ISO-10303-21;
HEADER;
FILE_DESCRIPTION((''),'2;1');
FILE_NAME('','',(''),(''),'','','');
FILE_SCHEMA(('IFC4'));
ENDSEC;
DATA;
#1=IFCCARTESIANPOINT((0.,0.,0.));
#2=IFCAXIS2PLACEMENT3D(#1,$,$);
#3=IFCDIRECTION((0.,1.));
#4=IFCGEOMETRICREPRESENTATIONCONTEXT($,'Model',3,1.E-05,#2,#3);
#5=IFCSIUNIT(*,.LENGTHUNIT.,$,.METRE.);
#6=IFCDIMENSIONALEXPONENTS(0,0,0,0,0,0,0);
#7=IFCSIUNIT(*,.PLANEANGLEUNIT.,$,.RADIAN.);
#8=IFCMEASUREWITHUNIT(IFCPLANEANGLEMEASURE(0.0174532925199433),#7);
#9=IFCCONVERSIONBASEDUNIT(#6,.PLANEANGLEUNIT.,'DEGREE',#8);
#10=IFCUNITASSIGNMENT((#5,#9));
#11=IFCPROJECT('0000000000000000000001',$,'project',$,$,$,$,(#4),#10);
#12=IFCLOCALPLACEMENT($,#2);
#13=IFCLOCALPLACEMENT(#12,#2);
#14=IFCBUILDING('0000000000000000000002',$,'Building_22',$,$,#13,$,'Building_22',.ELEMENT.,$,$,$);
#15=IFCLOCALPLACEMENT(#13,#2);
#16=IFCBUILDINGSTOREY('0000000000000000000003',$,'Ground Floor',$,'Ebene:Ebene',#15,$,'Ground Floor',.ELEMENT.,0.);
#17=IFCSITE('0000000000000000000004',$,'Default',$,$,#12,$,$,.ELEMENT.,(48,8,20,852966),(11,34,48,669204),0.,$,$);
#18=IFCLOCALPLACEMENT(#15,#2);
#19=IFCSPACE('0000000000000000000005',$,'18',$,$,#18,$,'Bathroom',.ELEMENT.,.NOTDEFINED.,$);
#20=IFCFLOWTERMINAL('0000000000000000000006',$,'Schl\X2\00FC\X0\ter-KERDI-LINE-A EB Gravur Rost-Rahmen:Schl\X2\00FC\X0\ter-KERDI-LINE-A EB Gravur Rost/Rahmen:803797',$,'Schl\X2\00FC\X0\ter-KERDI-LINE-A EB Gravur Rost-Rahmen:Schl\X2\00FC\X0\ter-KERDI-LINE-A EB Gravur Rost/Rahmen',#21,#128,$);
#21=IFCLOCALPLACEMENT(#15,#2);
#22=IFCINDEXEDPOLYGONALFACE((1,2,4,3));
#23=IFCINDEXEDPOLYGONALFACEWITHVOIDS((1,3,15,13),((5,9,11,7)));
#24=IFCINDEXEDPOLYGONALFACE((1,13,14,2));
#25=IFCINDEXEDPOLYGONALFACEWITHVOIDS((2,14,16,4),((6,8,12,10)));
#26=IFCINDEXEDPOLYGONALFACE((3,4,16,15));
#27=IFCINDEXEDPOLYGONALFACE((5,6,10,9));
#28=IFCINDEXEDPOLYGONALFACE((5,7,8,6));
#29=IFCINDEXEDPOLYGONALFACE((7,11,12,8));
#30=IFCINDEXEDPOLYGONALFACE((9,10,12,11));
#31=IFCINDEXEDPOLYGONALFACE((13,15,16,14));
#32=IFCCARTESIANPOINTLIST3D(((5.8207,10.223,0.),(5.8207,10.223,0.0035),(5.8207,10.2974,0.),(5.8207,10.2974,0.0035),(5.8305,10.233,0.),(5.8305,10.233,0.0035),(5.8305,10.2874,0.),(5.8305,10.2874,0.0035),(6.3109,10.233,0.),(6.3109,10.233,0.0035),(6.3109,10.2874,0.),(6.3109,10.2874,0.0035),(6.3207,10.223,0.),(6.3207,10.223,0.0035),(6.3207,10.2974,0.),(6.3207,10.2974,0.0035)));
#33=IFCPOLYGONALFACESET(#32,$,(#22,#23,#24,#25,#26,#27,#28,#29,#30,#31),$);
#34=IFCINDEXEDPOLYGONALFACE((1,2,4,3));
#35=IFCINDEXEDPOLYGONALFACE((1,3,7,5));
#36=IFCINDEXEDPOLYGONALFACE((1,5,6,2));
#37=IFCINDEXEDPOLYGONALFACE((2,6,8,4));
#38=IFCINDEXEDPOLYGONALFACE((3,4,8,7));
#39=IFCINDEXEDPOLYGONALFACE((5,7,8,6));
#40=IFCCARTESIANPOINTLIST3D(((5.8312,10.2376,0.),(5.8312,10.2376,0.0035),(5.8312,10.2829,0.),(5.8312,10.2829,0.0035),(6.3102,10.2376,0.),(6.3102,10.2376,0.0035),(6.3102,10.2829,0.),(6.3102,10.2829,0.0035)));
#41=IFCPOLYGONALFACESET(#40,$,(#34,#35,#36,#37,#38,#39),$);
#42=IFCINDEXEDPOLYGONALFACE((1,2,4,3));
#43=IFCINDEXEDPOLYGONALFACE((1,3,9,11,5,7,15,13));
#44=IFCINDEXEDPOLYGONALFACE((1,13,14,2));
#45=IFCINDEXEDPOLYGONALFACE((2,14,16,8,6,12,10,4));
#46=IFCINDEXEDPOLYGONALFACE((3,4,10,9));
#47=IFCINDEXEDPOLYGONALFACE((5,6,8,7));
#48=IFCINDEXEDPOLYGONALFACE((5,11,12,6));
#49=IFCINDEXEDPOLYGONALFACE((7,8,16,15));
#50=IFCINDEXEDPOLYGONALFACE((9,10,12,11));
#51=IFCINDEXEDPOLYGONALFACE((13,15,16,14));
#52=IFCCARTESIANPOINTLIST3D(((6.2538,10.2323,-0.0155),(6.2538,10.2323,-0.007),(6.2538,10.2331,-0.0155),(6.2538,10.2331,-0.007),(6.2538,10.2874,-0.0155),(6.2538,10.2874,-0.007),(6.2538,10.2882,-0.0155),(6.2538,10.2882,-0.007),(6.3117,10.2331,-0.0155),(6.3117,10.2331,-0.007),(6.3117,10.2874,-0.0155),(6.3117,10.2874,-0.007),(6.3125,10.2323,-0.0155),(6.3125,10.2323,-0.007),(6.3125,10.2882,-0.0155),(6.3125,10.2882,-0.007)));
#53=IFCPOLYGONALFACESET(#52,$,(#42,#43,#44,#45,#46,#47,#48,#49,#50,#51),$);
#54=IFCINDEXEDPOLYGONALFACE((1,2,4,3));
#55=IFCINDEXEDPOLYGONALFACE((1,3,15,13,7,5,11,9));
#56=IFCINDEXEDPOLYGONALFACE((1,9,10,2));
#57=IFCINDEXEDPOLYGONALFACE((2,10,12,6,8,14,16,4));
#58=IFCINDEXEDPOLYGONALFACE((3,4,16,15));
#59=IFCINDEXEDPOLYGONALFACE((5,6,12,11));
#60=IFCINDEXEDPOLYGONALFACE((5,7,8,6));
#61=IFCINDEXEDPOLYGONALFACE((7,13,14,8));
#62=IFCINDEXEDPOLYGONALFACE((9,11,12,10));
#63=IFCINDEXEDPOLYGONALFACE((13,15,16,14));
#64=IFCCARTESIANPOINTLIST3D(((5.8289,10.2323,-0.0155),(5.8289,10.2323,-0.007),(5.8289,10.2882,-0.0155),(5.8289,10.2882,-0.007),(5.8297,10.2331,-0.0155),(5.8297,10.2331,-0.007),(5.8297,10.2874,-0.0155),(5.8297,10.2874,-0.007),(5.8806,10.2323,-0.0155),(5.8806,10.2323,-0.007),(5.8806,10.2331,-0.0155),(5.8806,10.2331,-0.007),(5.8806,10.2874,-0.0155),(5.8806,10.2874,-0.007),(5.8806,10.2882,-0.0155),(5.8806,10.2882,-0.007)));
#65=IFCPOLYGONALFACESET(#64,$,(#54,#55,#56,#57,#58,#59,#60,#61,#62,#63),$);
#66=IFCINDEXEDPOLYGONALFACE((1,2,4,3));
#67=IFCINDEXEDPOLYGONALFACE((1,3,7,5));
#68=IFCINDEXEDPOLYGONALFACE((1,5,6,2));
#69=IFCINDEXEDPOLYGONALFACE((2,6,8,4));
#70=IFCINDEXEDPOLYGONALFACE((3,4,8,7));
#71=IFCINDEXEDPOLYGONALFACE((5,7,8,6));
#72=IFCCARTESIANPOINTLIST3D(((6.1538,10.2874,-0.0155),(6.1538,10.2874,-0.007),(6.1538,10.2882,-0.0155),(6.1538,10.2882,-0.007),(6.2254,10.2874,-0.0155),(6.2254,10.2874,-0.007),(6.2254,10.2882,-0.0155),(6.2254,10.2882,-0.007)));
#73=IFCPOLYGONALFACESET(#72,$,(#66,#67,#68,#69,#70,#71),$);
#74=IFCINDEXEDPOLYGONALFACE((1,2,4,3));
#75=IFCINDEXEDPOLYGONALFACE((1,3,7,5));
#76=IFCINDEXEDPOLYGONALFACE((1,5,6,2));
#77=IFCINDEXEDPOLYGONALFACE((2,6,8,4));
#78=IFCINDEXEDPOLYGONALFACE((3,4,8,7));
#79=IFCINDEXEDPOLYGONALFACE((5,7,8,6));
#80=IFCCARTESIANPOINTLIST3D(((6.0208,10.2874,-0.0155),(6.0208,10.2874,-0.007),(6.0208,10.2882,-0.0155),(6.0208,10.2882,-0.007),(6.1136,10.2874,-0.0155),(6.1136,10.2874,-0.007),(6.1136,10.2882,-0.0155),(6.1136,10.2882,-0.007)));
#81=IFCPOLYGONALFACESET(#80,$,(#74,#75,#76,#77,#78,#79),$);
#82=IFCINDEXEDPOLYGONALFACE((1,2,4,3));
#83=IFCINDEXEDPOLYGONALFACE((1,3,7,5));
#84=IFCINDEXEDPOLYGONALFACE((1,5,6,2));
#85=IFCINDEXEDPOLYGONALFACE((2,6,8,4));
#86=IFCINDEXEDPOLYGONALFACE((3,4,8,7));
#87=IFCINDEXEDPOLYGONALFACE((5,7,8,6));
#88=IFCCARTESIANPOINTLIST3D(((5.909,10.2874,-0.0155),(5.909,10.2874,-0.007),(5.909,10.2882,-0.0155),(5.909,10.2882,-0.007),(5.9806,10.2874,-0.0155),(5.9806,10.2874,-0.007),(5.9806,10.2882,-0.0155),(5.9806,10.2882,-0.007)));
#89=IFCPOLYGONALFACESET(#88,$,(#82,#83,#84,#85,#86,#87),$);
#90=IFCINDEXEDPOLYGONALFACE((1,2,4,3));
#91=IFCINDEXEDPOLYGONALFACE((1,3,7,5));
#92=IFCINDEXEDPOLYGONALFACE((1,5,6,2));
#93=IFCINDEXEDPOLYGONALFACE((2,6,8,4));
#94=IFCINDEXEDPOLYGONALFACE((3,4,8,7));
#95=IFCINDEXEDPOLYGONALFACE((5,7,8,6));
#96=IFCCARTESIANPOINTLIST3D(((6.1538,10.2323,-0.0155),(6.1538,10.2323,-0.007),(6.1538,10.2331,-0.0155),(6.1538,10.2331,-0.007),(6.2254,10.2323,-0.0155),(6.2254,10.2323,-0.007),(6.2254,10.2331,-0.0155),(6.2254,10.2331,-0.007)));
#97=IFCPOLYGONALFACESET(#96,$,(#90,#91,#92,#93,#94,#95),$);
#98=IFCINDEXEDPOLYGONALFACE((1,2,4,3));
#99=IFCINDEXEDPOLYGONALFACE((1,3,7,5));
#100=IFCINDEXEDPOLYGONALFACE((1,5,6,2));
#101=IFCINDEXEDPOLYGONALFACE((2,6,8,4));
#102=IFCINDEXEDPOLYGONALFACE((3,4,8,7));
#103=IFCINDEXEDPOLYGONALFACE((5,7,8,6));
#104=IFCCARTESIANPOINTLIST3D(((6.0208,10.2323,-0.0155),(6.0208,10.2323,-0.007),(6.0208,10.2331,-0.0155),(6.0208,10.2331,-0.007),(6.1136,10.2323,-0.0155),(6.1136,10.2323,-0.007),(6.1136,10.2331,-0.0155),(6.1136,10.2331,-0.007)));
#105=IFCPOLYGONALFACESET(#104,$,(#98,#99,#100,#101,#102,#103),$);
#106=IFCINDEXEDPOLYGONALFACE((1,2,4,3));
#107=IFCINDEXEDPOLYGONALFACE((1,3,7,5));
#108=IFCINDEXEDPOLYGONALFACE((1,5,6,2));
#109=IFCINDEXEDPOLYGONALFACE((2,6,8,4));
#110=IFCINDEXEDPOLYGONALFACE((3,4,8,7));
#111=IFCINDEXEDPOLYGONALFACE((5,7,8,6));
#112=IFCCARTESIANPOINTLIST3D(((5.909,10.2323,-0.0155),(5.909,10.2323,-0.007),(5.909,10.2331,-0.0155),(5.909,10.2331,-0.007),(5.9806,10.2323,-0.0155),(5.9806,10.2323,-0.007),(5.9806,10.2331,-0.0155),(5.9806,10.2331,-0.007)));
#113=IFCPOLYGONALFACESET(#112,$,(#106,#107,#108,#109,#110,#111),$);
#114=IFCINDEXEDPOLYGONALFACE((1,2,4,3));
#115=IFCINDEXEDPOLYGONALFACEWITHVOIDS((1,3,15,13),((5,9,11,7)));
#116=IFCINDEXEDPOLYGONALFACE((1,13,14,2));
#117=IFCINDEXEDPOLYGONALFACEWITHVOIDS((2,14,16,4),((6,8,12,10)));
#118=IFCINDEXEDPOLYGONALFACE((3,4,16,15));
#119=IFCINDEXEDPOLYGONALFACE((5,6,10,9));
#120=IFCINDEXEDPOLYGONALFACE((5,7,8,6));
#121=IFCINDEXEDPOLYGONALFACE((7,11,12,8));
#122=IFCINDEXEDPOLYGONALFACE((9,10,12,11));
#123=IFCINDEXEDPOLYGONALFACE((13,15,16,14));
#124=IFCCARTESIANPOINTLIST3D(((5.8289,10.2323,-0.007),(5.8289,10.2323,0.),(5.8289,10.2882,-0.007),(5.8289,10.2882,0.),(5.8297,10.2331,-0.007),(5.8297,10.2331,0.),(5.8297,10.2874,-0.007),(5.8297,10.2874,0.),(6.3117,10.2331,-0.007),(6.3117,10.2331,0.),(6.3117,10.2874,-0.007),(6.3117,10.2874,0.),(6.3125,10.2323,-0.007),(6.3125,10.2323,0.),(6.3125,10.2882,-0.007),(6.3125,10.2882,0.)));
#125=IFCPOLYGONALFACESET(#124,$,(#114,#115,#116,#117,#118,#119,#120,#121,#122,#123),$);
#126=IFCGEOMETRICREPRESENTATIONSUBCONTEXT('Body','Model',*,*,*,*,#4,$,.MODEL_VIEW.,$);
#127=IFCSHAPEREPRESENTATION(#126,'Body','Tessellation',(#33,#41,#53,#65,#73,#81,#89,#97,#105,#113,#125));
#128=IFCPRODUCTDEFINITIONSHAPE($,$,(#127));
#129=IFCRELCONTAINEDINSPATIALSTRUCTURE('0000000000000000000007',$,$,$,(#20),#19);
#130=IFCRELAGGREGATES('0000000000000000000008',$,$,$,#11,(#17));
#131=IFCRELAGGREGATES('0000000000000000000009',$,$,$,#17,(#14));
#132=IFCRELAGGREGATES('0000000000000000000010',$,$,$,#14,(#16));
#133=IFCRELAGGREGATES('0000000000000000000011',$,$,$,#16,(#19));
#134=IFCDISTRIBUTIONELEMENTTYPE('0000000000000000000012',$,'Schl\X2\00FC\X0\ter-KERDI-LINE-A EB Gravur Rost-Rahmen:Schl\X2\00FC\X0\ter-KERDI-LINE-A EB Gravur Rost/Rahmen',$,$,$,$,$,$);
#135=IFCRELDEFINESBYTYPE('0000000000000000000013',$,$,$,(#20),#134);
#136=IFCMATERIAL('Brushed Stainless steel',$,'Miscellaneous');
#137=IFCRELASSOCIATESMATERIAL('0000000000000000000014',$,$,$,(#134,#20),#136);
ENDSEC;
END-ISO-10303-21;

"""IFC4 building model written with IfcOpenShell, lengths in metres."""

from ifc_helpers import new_model, entity, si_unit, converted_unit, direction, frame, origin, place, context, subcontext, project, spatial, indexed_curve, outline, extrude, source, transform, mapped, material, type_object, type_shapes, element, save


model = new_model("IFC4")

# Units and contexts
model_context = context("Model", 3, precision=1e-05, world=origin(), true_north=direction((0.0, 1.0)))
body_context = subcontext(model_context, "Body", "Model", "MODEL_VIEW")
ifc_project = project(units=[si_unit("LENGTHUNIT", "METRE"), converted_unit("PLANEANGLEUNIT", "DEGREE", entity("IfcPlaneAngleMeasure", 0.0174532925199433), si_unit("PLANEANGLEUNIT", "RADIAN"), dimensions=[0, 0, 0, 0, 0, 0, 0])], contexts=[model_context])

# Site, building, storey
site_placement = place(None, origin())
site = spatial("IfcSite", under=ifc_project, at=site_placement, Name="Default", CompositionType="ELEMENT", RefLatitude=(48, 8, 20, 852966), RefLongitude=(11, 34, 48, 669204), RefElevation=0.0)
building_placement = place(site_placement, origin())
building = spatial("IfcBuilding", under=site, at=building_placement, Name="Building_22", LongName="Building_22", CompositionType="ELEMENT")
storey_placement = place(building_placement, origin())
storey = spatial("IfcBuildingStorey", under=building, at=storey_placement, Name="Ground Floor", ObjectType="Ebene:Ebene", LongName="Ground Floor", CompositionType="ELEMENT", Elevation=0.0)

# Shared definitions
ifc_material_1 = material(Name="Brushed Stainless steel", Category="Miscellaneous")

# Shared definitions
space_1_placement = place(storey_placement, origin())
space_1 = spatial("IfcSpace", under=storey, at=space_1_placement, Name="18", LongName="Bathroom", CompositionType="ELEMENT", PredefinedType="NOTDEFINED")

# Flow terminal
distribution_element_type_1 = type_object("IfcDistributionElementType", Name="Schlüter-KERDI-LINE-A EB Gravur Rost-Rahmen:Schlüter-KERDI-LINE-A EB Gravur Rost/Rahmen", material=ifc_material_1)
shared_shape_1 = source(origin(), body_context, "Body", "SweptSolid", [
    extrude(outline(indexed_curve([(-0.0372, -0.25), (0.0372, -0.25), (0.0372, 0.25), (-0.0372, 0.25), (-0.0372, -0.25)], self_intersect=False), holes=[indexed_curve([(0.0272, 0.2402), (0.0272, -0.2402), (-0.0272, -0.2402), (-0.0272, 0.2402), (0.0272, 0.2402)], self_intersect=False)]), frame((0.0, 0.0, 0.0), z_axis=(0.0, 0.0, 1.0), x_axis=(0.0, 1.0, 0.0)), (0.0, 0.0, 1.0), 0.0035),
    extrude(outline(indexed_curve([(-0.0227, -0.2395), (0.0227, -0.2395), (0.0227, 0.2395), (-0.0227, 0.2395), (-0.0227, -0.2395)], self_intersect=False)), frame((0.0, 0.0, 0.0), z_axis=(0.0, 0.0, 1.0), x_axis=(0.0, 1.0, 0.0)), (0.0, 0.0, 1.0), 0.0035),
    extrude(outline(indexed_curve([(-0.028, -0.0291), (-0.0272, -0.0291), (-0.0272, 0.0287), (0.0272, 0.0287), (0.0272, -0.0291), (0.028, -0.0291), (0.028, 0.0295), (-0.028, 0.0295), (-0.028, -0.0291)], self_intersect=False)), frame((-0.2123, 0.0, -0.0155), z_axis=(0.0, 0.0, 1.0), x_axis=(0.0, 1.0, 0.0)), (0.0, 0.0, 1.0), 0.0085),
    extrude(outline(indexed_curve([(-0.0252, 0.0272), (0.0256, 0.0272), (0.0256, 0.028), (-0.026, 0.028), (-0.026, -0.028), (0.0256, -0.028), (0.0256, -0.0272), (-0.0252, -0.0272), (-0.0252, 0.0272)], self_intersect=False)), frame((0.2158, 0.0, -0.0155), z_axis=(0.0, 0.0, 1.0), x_axis=(-1.0, 0.0, 0.0)), (0.0, 0.0, 1.0), 0.0085),
    extrude(outline(indexed_curve([(-0.0004, -0.0358), (0.0004, -0.0358), (0.0004, 0.0358), (-0.0004, 0.0358), (-0.0004, -0.0358)], self_intersect=False)), frame((-0.1189, -0.0276, -0.0155), z_axis=(0.0, 0.0, 1.0), x_axis=(0.0, -1.0, 0.0)), (0.0, 0.0, 1.0), 0.0085),
    extrude(outline(indexed_curve([(-0.0004, -0.0464), (0.0004, -0.0464), (0.0004, 0.0464), (-0.0004, 0.0464), (-0.0004, -0.0464)], self_intersect=False)), frame((0.0035, -0.0276, -0.0155), z_axis=(0.0, 0.0, 1.0), x_axis=(0.0, -1.0, 0.0)), (0.0, 0.0, 1.0), 0.0085),
    extrude(outline(indexed_curve([(-0.0004, -0.0358), (0.0004, -0.0358), (0.0004, 0.0358), (-0.0004, 0.0358), (-0.0004, -0.0358)], self_intersect=False)), frame((0.1259, -0.0276, -0.0155), z_axis=(0.0, 0.0, 1.0), x_axis=(0.0, -1.0, 0.0)), (0.0, 0.0, 1.0), 0.0085),
    extrude(outline(indexed_curve([(-0.0358, -0.0004), (0.0358, -0.0004), (0.0358, 0.0004), (-0.0358, 0.0004), (-0.0358, -0.0004)], self_intersect=False)), frame((-0.1189, 0.0276, -0.0155)), (0.0, 0.0, 1.0), 0.0085),
    extrude(outline(indexed_curve([(-0.0464, -0.0004), (0.0464, -0.0004), (0.0464, 0.0004), (-0.0464, 0.0004), (-0.0464, -0.0004)], self_intersect=False)), frame((0.0035, 0.0276, -0.0155)), (0.0, 0.0, 1.0), 0.0085),
    extrude(outline(indexed_curve([(-0.0358, -0.0004), (0.0358, -0.0004), (0.0358, 0.0004), (-0.0358, 0.0004), (-0.0358, -0.0004)], self_intersect=False)), frame((0.1259, 0.0276, -0.0155)), (0.0, 0.0, 1.0), 0.0085),
    extrude(outline(indexed_curve([(-0.028, -0.2418), (0.028, -0.2418), (0.028, 0.2418), (-0.028, 0.2418), (-0.028, -0.2418)], self_intersect=False), holes=[indexed_curve([(-0.0272, 0.241), (0.0272, 0.241), (0.0272, -0.241), (-0.0272, -0.241), (-0.0272, 0.241)], self_intersect=False)]), frame((0.0, 0.0, -0.007), z_axis=(0.0, 0.0, 1.0), x_axis=(0.0, 1.0, 0.0)), (0.0, 0.0, 1.0), 0.007),
])
type_shapes(distribution_element_type_1, [shared_shape_1])
flow_terminal_1_placement = place(space_1_placement, frame((6.0707, 10.2602, 0.0), z_axis=(0.0, 0.0, 1.0), x_axis=(-1.0, 0.0, 0.0)))
element("IfcFlowTerminal", 1, at=flow_terminal_1_placement, inside=space_1, type_object=distribution_element_type_1, material=ifc_material_1, Name="Schlüter-KERDI-LINE-A EB Gravur Rost-Rahmen:Schlüter-KERDI-LINE-A EB Gravur Rost/Rahmen:803797", ObjectType="Schlüter-KERDI-LINE-A EB Gravur Rost-Rahmen:Schlüter-KERDI-LINE-A EB Gravur Rost/Rahmen", context=body_context, shape_type="MappedRepresentation", body=[
    mapped(shared_shape_1, transform((0.0, 0.0, 0.0), scale=1.0)),
])

save(model, "model.ifc")
